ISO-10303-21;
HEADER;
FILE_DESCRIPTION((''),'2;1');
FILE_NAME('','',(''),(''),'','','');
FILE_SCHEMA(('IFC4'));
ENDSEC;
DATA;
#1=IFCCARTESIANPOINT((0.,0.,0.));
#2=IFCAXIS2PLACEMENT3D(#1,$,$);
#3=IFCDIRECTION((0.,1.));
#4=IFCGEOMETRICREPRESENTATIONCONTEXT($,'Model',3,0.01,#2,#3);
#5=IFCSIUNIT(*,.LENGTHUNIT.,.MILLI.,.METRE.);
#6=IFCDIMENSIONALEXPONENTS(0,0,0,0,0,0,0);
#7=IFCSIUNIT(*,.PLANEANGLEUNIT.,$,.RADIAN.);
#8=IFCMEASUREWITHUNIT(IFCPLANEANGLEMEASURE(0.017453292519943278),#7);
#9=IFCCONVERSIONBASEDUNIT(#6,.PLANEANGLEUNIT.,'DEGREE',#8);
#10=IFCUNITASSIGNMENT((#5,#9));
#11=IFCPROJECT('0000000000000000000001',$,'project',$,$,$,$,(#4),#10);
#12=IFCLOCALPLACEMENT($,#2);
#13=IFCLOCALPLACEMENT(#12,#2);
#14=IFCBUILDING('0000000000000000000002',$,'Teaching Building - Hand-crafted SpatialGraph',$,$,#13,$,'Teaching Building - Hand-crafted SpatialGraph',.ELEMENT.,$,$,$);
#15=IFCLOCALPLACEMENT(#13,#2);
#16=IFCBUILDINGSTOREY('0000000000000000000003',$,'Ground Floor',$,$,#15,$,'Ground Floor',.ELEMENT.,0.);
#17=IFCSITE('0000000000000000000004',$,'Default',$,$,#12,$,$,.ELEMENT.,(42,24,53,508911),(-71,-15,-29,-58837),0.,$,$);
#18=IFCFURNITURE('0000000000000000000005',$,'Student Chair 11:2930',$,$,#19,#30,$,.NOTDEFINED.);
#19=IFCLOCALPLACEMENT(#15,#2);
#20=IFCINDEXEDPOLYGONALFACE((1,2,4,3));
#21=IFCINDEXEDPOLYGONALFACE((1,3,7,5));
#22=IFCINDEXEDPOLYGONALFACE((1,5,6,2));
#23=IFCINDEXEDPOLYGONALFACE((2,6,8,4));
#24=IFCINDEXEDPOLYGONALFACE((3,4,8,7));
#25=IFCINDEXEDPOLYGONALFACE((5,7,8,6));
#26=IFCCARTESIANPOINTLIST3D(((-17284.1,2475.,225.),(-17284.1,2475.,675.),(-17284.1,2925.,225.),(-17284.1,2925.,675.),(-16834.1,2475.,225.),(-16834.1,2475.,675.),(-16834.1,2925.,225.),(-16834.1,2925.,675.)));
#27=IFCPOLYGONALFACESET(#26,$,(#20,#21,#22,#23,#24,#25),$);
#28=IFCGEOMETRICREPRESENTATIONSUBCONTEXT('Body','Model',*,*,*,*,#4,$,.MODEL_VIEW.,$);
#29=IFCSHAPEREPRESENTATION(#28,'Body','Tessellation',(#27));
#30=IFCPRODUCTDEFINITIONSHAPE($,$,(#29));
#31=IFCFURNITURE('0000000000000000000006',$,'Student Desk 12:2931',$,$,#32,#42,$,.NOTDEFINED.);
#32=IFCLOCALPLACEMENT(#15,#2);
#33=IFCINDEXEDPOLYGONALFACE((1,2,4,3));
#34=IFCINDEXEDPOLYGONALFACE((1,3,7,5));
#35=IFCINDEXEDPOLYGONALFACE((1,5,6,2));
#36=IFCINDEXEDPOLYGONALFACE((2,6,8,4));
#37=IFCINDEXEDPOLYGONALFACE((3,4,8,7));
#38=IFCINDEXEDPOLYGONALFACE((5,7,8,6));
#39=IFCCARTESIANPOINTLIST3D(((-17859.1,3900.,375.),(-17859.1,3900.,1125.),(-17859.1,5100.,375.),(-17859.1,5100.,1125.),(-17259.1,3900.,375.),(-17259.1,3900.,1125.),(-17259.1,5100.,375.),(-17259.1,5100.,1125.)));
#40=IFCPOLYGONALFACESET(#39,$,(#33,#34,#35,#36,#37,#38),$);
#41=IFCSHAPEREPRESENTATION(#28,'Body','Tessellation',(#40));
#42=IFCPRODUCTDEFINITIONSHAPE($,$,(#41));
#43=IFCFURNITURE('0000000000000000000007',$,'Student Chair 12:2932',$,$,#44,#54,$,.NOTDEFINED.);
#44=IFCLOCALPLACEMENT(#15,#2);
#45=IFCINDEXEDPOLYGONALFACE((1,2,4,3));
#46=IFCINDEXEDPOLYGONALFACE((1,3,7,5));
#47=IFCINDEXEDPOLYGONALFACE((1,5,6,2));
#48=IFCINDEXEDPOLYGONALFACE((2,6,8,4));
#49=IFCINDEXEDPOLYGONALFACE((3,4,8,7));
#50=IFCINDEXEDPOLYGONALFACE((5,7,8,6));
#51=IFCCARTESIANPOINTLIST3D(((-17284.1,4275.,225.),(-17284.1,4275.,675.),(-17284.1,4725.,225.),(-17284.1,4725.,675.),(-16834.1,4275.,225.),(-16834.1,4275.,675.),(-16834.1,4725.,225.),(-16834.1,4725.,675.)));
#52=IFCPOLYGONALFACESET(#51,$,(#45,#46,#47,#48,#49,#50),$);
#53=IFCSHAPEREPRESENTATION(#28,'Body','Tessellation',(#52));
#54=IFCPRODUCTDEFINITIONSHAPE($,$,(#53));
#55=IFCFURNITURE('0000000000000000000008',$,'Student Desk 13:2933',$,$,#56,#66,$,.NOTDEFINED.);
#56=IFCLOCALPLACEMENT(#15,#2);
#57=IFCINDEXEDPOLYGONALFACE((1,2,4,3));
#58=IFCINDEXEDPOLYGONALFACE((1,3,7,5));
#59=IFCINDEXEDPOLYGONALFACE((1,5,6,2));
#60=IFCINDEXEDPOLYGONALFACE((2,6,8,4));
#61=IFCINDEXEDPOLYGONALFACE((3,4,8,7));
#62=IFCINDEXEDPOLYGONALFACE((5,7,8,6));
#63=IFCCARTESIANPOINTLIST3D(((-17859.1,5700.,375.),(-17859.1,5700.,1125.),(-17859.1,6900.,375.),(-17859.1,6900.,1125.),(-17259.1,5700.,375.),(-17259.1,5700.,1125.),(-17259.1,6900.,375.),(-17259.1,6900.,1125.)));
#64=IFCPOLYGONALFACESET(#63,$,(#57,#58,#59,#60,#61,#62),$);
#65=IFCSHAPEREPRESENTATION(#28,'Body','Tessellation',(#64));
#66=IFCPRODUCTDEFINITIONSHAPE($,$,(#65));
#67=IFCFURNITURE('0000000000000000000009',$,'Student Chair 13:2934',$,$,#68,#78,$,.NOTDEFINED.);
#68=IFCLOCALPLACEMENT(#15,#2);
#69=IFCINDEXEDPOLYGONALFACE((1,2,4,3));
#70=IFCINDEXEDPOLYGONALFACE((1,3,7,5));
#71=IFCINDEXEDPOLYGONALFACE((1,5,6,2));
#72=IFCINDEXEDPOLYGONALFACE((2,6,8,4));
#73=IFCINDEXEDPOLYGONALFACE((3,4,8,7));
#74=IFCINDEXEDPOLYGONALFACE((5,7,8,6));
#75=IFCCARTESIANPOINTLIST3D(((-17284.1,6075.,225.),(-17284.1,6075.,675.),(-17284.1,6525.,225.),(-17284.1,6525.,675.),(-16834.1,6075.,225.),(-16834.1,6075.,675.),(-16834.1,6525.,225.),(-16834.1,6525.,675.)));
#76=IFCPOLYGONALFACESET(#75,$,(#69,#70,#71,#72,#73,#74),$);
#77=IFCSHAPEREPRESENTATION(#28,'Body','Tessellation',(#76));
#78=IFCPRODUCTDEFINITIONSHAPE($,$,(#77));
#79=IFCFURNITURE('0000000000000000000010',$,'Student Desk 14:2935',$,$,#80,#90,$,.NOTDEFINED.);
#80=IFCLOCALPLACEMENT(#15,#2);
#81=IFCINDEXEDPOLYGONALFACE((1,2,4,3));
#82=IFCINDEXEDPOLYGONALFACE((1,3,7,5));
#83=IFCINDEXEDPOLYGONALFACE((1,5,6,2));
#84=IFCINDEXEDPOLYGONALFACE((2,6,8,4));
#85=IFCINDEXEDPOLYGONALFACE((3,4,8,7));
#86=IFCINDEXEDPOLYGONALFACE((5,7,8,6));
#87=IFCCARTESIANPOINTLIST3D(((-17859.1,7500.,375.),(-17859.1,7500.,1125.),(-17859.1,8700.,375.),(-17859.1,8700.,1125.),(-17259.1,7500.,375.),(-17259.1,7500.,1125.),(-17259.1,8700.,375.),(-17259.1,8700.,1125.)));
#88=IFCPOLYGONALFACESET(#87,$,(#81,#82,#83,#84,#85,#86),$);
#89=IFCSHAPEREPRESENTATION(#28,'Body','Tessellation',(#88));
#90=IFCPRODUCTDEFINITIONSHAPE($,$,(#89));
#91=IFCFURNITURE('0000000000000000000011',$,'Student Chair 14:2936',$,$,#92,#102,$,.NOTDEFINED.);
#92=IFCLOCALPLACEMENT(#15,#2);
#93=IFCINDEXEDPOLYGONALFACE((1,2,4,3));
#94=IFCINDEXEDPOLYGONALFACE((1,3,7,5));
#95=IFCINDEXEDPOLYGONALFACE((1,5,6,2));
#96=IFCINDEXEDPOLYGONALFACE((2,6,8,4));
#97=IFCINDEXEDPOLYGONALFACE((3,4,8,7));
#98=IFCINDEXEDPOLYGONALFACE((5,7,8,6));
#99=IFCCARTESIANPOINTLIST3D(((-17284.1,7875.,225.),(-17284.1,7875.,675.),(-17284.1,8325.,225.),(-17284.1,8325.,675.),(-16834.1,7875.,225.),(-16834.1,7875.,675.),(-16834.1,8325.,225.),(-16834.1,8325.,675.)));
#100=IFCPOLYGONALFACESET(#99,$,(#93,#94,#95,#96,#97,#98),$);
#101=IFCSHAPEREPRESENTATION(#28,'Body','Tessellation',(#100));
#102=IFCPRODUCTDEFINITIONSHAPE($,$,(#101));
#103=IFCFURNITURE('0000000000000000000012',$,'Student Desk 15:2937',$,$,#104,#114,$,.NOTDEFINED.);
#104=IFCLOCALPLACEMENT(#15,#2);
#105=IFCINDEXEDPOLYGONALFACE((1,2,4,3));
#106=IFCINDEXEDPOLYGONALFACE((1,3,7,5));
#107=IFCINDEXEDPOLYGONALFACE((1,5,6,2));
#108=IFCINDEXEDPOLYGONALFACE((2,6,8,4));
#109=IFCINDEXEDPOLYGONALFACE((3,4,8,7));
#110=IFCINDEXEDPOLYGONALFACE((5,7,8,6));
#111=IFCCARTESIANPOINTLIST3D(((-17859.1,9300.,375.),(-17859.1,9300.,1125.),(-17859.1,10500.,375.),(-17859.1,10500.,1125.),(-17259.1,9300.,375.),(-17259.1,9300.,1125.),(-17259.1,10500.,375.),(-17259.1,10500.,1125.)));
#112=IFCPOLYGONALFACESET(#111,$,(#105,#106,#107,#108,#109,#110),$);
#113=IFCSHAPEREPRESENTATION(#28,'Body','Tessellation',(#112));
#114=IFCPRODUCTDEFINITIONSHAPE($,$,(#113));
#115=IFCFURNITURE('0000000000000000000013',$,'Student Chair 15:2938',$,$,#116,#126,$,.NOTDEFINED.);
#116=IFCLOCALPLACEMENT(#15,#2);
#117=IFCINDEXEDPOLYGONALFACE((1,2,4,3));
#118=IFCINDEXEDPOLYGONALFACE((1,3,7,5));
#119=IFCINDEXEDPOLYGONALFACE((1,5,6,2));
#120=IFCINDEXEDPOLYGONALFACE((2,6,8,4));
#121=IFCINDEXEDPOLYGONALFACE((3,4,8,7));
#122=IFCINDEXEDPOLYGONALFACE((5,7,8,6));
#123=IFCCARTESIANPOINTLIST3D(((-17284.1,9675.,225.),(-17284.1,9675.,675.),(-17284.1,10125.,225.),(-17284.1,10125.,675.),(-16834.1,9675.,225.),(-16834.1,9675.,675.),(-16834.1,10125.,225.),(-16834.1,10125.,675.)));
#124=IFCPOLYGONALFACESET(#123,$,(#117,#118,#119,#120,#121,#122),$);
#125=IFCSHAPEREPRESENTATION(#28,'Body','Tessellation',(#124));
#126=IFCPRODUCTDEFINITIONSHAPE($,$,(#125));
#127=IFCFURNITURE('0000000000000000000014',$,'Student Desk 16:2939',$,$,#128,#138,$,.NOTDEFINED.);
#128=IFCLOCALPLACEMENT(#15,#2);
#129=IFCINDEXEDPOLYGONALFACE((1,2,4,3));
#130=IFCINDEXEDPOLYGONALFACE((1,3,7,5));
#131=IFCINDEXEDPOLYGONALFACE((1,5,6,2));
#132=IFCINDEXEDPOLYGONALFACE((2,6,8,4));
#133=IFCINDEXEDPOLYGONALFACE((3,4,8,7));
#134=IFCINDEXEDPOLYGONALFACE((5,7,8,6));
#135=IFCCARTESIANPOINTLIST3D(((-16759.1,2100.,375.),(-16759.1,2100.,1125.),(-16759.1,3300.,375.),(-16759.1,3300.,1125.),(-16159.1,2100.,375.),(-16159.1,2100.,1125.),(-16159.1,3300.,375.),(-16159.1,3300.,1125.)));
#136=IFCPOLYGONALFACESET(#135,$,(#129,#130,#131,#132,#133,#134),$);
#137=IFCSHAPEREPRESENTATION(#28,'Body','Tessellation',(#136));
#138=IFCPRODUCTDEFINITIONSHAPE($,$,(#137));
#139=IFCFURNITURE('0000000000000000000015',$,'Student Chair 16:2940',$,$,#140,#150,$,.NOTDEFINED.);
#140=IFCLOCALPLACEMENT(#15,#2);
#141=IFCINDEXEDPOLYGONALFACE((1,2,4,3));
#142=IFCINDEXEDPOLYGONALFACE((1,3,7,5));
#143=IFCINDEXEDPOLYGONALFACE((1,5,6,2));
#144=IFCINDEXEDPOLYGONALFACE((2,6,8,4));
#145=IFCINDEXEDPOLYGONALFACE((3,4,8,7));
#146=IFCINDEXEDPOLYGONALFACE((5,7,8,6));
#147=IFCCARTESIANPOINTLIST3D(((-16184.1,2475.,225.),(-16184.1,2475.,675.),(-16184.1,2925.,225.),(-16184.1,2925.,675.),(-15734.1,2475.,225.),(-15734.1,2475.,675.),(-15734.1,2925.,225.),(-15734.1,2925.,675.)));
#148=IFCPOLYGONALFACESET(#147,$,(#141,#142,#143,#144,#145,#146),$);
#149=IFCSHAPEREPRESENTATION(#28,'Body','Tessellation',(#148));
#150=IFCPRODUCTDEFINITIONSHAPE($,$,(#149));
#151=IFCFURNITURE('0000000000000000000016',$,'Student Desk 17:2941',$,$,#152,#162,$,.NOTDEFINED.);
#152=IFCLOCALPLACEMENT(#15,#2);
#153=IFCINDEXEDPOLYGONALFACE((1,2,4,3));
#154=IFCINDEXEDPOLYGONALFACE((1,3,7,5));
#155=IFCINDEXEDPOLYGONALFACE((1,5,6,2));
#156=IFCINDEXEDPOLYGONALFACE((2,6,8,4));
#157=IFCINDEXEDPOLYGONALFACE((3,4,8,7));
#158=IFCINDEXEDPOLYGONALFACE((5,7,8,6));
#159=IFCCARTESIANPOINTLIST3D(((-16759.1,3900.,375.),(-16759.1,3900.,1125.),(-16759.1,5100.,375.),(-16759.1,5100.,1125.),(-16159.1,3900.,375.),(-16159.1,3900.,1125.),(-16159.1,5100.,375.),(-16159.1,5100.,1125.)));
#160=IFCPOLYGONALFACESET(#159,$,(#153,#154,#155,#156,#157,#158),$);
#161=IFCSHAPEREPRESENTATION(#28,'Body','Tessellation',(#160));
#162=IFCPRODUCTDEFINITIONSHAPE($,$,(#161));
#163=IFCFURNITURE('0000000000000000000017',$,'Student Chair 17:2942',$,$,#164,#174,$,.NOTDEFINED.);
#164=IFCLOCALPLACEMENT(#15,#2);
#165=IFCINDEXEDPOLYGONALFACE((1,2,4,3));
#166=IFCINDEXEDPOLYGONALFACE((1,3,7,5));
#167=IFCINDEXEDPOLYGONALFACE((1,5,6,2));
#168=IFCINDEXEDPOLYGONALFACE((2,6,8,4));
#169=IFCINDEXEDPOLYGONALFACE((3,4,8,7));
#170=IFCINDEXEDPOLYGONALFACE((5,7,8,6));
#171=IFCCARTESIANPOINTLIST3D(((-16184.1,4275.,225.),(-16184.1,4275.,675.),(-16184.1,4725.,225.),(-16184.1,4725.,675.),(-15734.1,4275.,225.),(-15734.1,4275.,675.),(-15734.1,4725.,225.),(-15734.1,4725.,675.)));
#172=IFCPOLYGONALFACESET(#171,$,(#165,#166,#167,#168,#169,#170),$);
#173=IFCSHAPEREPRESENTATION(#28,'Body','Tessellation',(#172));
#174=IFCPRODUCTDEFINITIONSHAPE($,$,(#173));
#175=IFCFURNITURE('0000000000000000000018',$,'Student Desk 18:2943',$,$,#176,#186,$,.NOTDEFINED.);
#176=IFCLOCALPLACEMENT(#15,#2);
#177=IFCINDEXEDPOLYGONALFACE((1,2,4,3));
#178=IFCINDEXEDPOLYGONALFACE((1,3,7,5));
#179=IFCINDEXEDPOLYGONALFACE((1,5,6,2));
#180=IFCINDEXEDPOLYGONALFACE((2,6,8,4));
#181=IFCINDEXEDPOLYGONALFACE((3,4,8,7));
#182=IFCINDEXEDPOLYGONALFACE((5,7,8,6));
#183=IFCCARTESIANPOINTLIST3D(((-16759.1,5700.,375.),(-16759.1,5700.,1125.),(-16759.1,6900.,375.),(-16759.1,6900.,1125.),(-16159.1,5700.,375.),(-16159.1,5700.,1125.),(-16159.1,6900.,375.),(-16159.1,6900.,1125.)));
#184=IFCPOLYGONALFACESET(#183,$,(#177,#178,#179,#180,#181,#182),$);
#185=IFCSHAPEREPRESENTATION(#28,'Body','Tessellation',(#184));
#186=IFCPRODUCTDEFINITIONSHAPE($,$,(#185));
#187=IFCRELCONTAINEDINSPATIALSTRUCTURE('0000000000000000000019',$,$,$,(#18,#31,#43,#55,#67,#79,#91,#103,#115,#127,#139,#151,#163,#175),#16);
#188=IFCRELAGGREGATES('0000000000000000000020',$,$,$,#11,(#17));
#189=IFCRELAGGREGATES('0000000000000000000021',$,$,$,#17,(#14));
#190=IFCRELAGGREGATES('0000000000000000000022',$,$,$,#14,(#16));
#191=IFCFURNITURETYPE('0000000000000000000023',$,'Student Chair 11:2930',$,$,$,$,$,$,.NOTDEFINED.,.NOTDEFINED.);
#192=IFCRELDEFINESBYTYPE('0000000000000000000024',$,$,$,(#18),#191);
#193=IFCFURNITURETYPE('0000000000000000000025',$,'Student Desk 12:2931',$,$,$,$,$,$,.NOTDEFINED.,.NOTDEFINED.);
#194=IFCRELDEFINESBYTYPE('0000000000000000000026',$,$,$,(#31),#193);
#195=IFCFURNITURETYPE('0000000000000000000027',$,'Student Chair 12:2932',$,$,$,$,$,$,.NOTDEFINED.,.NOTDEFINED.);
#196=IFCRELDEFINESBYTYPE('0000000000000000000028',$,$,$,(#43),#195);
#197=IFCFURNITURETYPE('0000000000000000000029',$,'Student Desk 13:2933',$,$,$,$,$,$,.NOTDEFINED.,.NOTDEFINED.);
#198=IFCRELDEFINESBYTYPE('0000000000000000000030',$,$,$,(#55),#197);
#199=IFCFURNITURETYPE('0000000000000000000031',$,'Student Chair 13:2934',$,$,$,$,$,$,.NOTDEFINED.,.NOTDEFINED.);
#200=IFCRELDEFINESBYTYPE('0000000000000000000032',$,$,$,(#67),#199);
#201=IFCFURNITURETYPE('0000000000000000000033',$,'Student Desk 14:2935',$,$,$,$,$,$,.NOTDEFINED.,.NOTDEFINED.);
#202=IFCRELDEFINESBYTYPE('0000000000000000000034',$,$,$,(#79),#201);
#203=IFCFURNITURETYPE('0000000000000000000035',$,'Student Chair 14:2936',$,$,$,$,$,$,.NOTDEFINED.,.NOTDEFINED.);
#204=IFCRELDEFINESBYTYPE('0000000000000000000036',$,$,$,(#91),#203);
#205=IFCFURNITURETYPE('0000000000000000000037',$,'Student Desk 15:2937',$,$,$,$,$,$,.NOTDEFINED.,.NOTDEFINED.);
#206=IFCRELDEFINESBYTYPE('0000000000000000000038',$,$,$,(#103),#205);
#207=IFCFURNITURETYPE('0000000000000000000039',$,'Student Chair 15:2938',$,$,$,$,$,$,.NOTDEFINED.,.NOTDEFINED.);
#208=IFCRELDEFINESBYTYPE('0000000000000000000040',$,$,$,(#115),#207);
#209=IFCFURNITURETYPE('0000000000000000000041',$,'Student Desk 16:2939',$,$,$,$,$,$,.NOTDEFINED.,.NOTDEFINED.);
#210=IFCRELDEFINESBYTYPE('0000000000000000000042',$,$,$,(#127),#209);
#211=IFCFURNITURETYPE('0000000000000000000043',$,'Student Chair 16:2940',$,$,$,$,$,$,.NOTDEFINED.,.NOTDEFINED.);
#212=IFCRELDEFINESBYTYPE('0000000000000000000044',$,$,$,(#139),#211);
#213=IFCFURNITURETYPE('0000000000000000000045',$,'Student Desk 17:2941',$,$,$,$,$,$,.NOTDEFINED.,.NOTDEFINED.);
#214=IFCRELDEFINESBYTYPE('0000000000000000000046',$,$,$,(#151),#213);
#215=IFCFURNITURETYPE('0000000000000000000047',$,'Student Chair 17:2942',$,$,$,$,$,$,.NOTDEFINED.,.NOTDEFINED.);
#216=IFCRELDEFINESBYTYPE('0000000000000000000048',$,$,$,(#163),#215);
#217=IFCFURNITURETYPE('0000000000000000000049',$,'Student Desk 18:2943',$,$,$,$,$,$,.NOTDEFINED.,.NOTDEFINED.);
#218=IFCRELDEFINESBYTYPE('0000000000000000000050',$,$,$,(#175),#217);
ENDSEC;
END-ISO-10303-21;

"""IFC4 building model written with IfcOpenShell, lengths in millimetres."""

from ifc_helpers import new_model, entity, si_unit, converted_unit, direction, frame, frame_2d, origin, origin_2d_with_axis, place, context, subcontext, project, spatial, rectangle, extrude, type_object, element, save


model = new_model("IFC4")

# Units and contexts
model_context = context("Model", 3, precision=0.01, world=origin(), true_north=direction((0.0, 1.0)))
body_context = subcontext(model_context, "Body", "Model", "MODEL_VIEW")
ifc_project = project(units=[si_unit("LENGTHUNIT", "METRE", prefix="MILLI"), converted_unit("PLANEANGLEUNIT", "DEGREE", entity("IfcPlaneAngleMeasure", 0.017453292519943278), si_unit("PLANEANGLEUNIT", "RADIAN"), dimensions=[0, 0, 0, 0, 0, 0, 0])], contexts=[model_context])

# Site, building, storey
site_placement = place(None, origin())
site = spatial("IfcSite", under=ifc_project, at=site_placement, Name="Default", CompositionType="ELEMENT", RefLatitude=(42, 24, 53, 508911), RefLongitude=(-71, -15, -29, -58837), RefElevation=0.0)
building_placement = place(site_placement, origin())
building = spatial("IfcBuilding", under=site, at=building_placement, Name="Teaching Building - Hand-crafted SpatialGraph", LongName="Teaching Building - Hand-crafted SpatialGraph", CompositionType="ELEMENT")
storey_placement = place(building_placement, origin())
storey = spatial("IfcBuildingStorey", under=building, at=storey_placement, Name="Ground Floor", LongName="Ground Floor", CompositionType="ELEMENT", Elevation=0.0)

# Furniture
furniture_type_1 = type_object("IfcFurnitureType", Name="Student Chair 11:2930", PredefinedType="NOTDEFINED")
furniture_1_placement = place(storey_placement, origin())
element("IfcFurniture", 1, at=furniture_1_placement, inside=storey, type_object=furniture_type_1, Name="Student Chair 11:2930", PredefinedType="NOTDEFINED", context=body_context, shape_type="SweptSolid", body=[
    extrude(rectangle(XDim=450.0, YDim=450.0, at=origin_2d_with_axis()), frame((-17059.1, 2700.0, 225.0)), (0.0, 0.0, 1.0), 450.0),
])
furniture_type_2 = type_object("IfcFurnitureType", Name="Student Desk 12:2931", PredefinedType="NOTDEFINED")
furniture_2_placement = place(storey_placement, origin())
element("IfcFurniture", 2, at=furniture_2_placement, inside=storey, type_object=furniture_type_2, Name="Student Desk 12:2931", PredefinedType="NOTDEFINED", context=body_context, shape_type="SweptSolid", body=[
    extrude(rectangle(XDim=1200.0, YDim=600.0, at=frame_2d((0.0, 0.0), x_axis=(1.0, 0.0))), frame((-17559.1, 4500.0, 375.0), z_axis=(0.0, 0.0, 1.0), x_axis=(0.0, 1.0, 0.0)), (0.0, 0.0, 1.0), 750.0),
])
furniture_type_3 = type_object("IfcFurnitureType", Name="Student Chair 12:2932", PredefinedType="NOTDEFINED")
furniture_3_placement = place(storey_placement, origin())
element("IfcFurniture", 3, at=furniture_3_placement, inside=storey, type_object=furniture_type_3, Name="Student Chair 12:2932", PredefinedType="NOTDEFINED", context=body_context, shape_type="SweptSolid", body=[
    extrude(rectangle(XDim=450.0, YDim=450.0, at=origin_2d_with_axis()), frame((-17059.1, 4500.0, 225.0)), (0.0, 0.0, 1.0), 450.0),
])
furniture_type_4 = type_object("IfcFurnitureType", Name="Student Desk 13:2933", PredefinedType="NOTDEFINED")
furniture_4_placement = place(storey_placement, origin())
element("IfcFurniture", 4, at=furniture_4_placement, inside=storey, type_object=furniture_type_4, Name="Student Desk 13:2933", PredefinedType="NOTDEFINED", context=body_context, shape_type="SweptSolid", body=[
    extrude(rectangle(XDim=1200.0, YDim=600.0, at=origin_2d_with_axis()), frame((-17559.1, 6300.0, 375.0), z_axis=(0.0, 0.0, 1.0), x_axis=(0.0, 1.0, 0.0)), (0.0, 0.0, 1.0), 750.0),
])
furniture_type_5 = type_object("IfcFurnitureType", Name="Student Chair 13:2934", PredefinedType="NOTDEFINED")
furniture_5_placement = place(storey_placement, origin())
element("IfcFurniture", 5, at=furniture_5_placement, inside=storey, type_object=furniture_type_5, Name="Student Chair 13:2934", PredefinedType="NOTDEFINED", context=body_context, shape_type="SweptSolid", body=[
    extrude(rectangle(XDim=450.0, YDim=450.0, at=origin_2d_with_axis()), frame((-17059.1, 6300.0, 225.0)), (0.0, 0.0, 1.0), 450.0),
])
furniture_type_6 = type_object("IfcFurnitureType", Name="Student Desk 14:2935", PredefinedType="NOTDEFINED")
furniture_6_placement = place(storey_placement, origin())
element("IfcFurniture", 6, at=furniture_6_placement, inside=storey, type_object=furniture_type_6, Name="Student Desk 14:2935", PredefinedType="NOTDEFINED", context=body_context, shape_type="SweptSolid", body=[
    extrude(rectangle(XDim=1200.0, YDim=600.0, at=origin_2d_with_axis()), frame((-17559.1, 8100.0, 375.0), z_axis=(0.0, 0.0, 1.0), x_axis=(0.0, 1.0, 0.0)), (0.0, 0.0, 1.0), 750.0),
])
furniture_type_7 = type_object("IfcFurnitureType", Name="Student Chair 14:2936", PredefinedType="NOTDEFINED")
furniture_7_placement = place(storey_placement, origin())
element("IfcFurniture", 7, at=furniture_7_placement, inside=storey, type_object=furniture_type_7, Name="Student Chair 14:2936", PredefinedType="NOTDEFINED", context=body_context, shape_type="SweptSolid", body=[
    extrude(rectangle(XDim=450.0, YDim=450.0, at=origin_2d_with_axis()), frame((-17059.1, 8100.0, 225.0)), (0.0, 0.0, 1.0), 450.0),
])
furniture_type_8 = type_object("IfcFurnitureType", Name="Student Desk 15:2937", PredefinedType="NOTDEFINED")
furniture_8_placement = place(storey_placement, origin())
element("IfcFurniture", 8, at=furniture_8_placement, inside=storey, type_object=furniture_type_8, Name="Student Desk 15:2937", PredefinedType="NOTDEFINED", context=body_context, shape_type="SweptSolid", body=[
    extrude(rectangle(XDim=1200.0, YDim=600.0, at=origin_2d_with_axis()), frame((-17559.1, 9900.0, 375.0), z_axis=(0.0, 0.0, 1.0), x_axis=(0.0, 1.0, 0.0)), (0.0, 0.0, 1.0), 750.0),
])
furniture_type_9 = type_object("IfcFurnitureType", Name="Student Chair 15:2938", PredefinedType="NOTDEFINED")
furniture_9_placement = place(storey_placement, origin())
element("IfcFurniture", 9, at=furniture_9_placement, inside=storey, type_object=furniture_type_9, Name="Student Chair 15:2938", PredefinedType="NOTDEFINED", context=body_context, shape_type="SweptSolid", body=[
    extrude(rectangle(XDim=450.0, YDim=450.0, at=frame_2d((0.0, 0.0), x_axis=(1.0, 0.0))), frame((-17059.1, 9900.0, 225.0)), (0.0, 0.0, 1.0), 450.0),
])
furniture_type_10 = type_object("IfcFurnitureType", Name="Student Desk 16:2939", PredefinedType="NOTDEFINED")
furniture_10_placement = place(storey_placement, origin())
element("IfcFurniture", 10, at=furniture_10_placement, inside=storey, type_object=furniture_type_10, Name="Student Desk 16:2939", PredefinedType="NOTDEFINED", context=body_context, shape_type="SweptSolid", body=[
    extrude(rectangle(XDim=1200.0, YDim=600.0, at=origin_2d_with_axis()), frame((-16459.1, 2700.0, 375.0), z_axis=(0.0, 0.0, 1.0), x_axis=(0.0, 1.0, 0.0)), (0.0, 0.0, 1.0), 750.0),
])
furniture_type_11 = type_object("IfcFurnitureType", Name="Student Chair 16:2940", PredefinedType="NOTDEFINED")
furniture_11_placement = place(storey_placement, origin())
element("IfcFurniture", 11, at=furniture_11_placement, inside=storey, type_object=furniture_type_11, Name="Student Chair 16:2940", PredefinedType="NOTDEFINED", context=body_context, shape_type="SweptSolid", body=[
    extrude(rectangle(XDim=450.0, YDim=450.0, at=origin_2d_with_axis()), frame((-15959.1, 2700.0, 225.0)), (0.0, 0.0, 1.0), 450.0),
])
furniture_type_12 = type_object("IfcFurnitureType", Name="Student Desk 17:2941", PredefinedType="NOTDEFINED")
furniture_12_placement = place(storey_placement, origin())
element("IfcFurniture", 12, at=furniture_12_placement, inside=storey, type_object=furniture_type_12, Name="Student Desk 17:2941", PredefinedType="NOTDEFINED", context=body_context, shape_type="SweptSolid", body=[
    extrude(rectangle(XDim=1200.0, YDim=600.0, at=frame_2d((0.0, 0.0), x_axis=(1.0, 0.0))), frame((-16459.1, 4500.0, 375.0), z_axis=(0.0, 0.0, 1.0), x_axis=(0.0, 1.0, 0.0)), (0.0, 0.0, 1.0), 750.0),
])
furniture_type_13 = type_object("IfcFurnitureType", Name="Student Chair 17:2942", PredefinedType="NOTDEFINED")
furniture_13_placement = place(storey_placement, origin())
element("IfcFurniture", 13, at=furniture_13_placement, inside=storey, type_object=furniture_type_13, Name="Student Chair 17:2942", PredefinedType="NOTDEFINED", context=body_context, shape_type="SweptSolid", body=[
    extrude(rectangle(XDim=450.0, YDim=450.0, at=origin_2d_with_axis()), frame((-15959.1, 4500.0, 225.0)), (0.0, 0.0, 1.0), 450.0),
])
furniture_type_14 = type_object("IfcFurnitureType", Name="Student Desk 18:2943", PredefinedType="NOTDEFINED")
furniture_14_placement = place(storey_placement, origin())
element("IfcFurniture", 14, at=furniture_14_placement, inside=storey, type_object=furniture_type_14, Name="Student Desk 18:2943", PredefinedType="NOTDEFINED", context=body_context, shape_type="SweptSolid", body=[
    extrude(rectangle(XDim=1200.0, YDim=600.0, at=origin_2d_with_axis()), frame((-16459.1, 6300.0, 375.0), z_axis=(0.0, 0.0, 1.0), x_axis=(0.0, 1.0, 0.0)), (0.0, 0.0, 1.0), 750.0),
])

save(model, "model.ifc")
